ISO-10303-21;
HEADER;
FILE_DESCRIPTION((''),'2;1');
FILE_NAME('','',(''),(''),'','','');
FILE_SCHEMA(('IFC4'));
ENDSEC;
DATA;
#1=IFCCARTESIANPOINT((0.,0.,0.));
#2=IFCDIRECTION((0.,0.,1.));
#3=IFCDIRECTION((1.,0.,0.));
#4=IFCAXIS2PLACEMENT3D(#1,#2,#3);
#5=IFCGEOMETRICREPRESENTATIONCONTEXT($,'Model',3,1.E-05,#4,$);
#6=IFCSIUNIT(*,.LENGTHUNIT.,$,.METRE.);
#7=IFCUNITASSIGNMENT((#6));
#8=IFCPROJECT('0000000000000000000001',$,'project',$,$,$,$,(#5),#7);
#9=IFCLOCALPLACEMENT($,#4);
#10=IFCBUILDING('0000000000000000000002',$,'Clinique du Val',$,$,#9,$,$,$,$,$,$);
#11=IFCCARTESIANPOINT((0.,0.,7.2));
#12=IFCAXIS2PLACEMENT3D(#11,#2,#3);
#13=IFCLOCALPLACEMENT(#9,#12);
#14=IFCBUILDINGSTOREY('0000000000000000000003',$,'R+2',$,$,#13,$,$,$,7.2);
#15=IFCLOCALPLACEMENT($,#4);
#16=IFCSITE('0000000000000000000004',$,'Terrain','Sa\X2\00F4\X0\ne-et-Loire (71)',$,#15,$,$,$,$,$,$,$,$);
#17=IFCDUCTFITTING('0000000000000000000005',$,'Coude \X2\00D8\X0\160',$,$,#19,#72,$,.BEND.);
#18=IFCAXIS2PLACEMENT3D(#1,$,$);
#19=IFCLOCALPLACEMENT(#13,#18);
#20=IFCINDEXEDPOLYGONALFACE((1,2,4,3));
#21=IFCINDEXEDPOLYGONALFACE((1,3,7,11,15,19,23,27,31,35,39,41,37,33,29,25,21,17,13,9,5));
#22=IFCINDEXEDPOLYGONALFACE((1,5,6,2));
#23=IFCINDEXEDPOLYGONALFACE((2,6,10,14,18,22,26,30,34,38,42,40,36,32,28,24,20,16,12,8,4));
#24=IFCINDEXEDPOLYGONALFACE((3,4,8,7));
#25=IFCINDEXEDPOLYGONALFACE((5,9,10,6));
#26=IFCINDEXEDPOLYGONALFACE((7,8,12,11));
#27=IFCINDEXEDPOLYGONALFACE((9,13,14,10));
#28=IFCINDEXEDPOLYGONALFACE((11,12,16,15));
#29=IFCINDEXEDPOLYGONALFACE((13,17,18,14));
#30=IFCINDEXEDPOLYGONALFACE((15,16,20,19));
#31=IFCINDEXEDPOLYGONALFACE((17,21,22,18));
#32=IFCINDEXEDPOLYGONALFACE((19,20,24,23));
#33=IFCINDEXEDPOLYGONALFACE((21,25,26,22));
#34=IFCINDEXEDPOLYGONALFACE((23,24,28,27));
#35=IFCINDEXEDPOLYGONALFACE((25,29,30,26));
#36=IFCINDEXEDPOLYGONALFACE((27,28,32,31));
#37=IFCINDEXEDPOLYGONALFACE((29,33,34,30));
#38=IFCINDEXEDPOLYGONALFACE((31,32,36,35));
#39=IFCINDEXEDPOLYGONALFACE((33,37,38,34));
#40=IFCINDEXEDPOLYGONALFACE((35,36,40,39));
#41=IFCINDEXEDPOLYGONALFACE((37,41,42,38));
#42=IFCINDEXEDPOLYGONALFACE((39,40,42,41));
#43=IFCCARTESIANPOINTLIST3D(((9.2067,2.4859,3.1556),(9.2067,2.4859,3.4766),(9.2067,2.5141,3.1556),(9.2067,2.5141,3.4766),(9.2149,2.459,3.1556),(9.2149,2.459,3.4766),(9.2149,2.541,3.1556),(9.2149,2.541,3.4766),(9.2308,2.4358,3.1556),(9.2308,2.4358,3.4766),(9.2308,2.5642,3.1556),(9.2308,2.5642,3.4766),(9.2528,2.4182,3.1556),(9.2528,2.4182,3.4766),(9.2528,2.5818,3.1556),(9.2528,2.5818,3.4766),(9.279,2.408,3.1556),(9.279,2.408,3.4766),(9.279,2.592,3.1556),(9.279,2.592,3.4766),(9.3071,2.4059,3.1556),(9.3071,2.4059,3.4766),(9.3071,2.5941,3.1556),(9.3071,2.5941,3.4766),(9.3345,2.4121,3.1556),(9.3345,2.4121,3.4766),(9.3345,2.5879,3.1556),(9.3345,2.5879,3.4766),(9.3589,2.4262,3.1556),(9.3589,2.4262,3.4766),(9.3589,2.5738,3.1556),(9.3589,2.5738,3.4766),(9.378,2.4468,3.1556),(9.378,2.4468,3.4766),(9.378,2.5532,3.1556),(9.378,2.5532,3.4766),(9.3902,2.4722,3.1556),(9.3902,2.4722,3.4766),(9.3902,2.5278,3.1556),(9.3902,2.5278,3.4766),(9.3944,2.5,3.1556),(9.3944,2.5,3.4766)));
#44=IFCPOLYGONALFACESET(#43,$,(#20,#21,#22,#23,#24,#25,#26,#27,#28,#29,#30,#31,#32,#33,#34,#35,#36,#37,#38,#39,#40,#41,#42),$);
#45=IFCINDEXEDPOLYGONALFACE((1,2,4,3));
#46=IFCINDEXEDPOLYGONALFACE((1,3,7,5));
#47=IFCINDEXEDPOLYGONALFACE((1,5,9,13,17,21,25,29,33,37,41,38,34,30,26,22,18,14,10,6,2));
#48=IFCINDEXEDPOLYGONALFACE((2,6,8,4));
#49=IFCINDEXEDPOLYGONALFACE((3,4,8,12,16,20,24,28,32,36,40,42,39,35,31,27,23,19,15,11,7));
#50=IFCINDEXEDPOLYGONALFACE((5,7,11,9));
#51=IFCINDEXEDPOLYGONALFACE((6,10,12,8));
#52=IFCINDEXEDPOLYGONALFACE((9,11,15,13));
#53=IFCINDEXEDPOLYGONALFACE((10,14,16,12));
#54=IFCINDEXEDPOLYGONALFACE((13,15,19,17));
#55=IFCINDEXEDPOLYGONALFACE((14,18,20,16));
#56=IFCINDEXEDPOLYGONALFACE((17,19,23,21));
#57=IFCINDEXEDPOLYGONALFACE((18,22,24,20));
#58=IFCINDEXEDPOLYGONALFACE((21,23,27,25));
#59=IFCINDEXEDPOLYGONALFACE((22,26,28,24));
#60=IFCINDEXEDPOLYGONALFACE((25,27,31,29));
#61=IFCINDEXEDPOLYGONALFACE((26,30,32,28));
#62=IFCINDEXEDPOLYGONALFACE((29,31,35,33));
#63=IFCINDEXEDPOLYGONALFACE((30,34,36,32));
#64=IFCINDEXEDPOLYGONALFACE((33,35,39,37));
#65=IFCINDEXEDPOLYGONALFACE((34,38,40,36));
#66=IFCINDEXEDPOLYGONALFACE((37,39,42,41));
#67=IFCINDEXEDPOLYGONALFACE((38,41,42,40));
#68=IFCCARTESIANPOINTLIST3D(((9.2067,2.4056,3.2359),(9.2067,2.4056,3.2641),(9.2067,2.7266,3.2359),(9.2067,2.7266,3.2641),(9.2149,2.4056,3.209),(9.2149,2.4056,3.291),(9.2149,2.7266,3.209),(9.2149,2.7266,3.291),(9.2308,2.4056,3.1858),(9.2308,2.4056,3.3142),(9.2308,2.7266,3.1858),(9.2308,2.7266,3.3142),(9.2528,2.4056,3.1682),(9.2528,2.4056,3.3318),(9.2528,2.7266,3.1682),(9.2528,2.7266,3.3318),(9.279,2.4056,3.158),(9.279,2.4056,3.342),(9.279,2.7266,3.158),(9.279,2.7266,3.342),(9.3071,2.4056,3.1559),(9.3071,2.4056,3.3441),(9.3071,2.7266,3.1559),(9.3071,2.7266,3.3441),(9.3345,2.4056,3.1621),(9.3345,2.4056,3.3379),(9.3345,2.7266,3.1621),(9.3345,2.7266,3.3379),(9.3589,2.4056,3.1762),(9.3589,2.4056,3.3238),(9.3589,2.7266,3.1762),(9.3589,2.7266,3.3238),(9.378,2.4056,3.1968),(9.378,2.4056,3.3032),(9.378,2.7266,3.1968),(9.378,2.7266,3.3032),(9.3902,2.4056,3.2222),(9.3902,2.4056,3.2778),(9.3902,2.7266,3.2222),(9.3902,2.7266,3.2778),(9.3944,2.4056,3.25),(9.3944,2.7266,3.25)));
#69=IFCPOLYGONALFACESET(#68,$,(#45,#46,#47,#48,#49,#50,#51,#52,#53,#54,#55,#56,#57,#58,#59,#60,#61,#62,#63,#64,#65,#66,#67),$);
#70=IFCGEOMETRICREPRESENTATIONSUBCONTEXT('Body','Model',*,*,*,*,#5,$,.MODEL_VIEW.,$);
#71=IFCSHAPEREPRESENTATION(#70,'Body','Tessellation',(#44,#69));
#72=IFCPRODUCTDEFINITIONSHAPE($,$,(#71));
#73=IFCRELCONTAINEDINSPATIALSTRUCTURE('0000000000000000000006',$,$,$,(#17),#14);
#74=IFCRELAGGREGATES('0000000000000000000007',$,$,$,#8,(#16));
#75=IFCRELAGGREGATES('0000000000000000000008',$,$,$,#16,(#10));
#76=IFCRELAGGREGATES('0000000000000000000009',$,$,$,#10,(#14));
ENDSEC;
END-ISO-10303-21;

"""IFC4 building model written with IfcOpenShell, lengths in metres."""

from ifc_helpers import new_model, si_unit, frame, origin_with_axes, place, context, subcontext, project, spatial, circle, extrude, element, save


model = new_model("IFC4")

# Units and contexts
model_context = context("Model", 3, precision=1e-05, world=origin_with_axes())
body_context = subcontext(model_context, "Body", "Model", "MODEL_VIEW")
ifc_project = project(units=[si_unit("LENGTHUNIT", "METRE")], contexts=[model_context])

# Site, building, storey
site_placement = place(None, origin_with_axes())
site = spatial("IfcSite", under=ifc_project, at=site_placement, Name="Terrain", Description="Saône-et-Loire (71)")
building_placement = place(None, origin_with_axes())
building = spatial("IfcBuilding", under=site, at=building_placement, Name="Clinique du Val")
storey_placement = place(building_placement, frame((0.0, 0.0, 7.2), z_axis=(0.0, 0.0, 1.0), x_axis=(1.0, 0.0, 0.0)))
storey = spatial("IfcBuildingStorey", under=building, at=storey_placement, Name="R+2", Elevation=7.2)

# Duct fitting
duct_fitting_1_placement = place(storey_placement, frame((9.3, 2.5, 3.25), z_axis=(0.0, 0.0, 1.0), x_axis=(1.0, 0.0, 0.0)))
element("IfcDuctFitting", 1, at=duct_fitting_1_placement, inside=storey, Name="Coude Ø160", PredefinedType="BEND", context=body_context, shape_type="SweptSolid", body=[
    extrude(circle(Radius=0.0944), frame((0.0, 0.0, -0.0944), z_axis=(0.0, 0.0, 1.0), x_axis=(1.0, 0.0, 0.0)), (0.0, 0.0, 1.0), 0.321),
    extrude(circle(Radius=0.0944), frame((0.0, -0.0944, 0.0), z_axis=(0.0, 1.0, 0.0), x_axis=(1.0, 0.0, 0.0)), (0.0, 0.0, 1.0), 0.321),
])

save(model, "model.ifc")
